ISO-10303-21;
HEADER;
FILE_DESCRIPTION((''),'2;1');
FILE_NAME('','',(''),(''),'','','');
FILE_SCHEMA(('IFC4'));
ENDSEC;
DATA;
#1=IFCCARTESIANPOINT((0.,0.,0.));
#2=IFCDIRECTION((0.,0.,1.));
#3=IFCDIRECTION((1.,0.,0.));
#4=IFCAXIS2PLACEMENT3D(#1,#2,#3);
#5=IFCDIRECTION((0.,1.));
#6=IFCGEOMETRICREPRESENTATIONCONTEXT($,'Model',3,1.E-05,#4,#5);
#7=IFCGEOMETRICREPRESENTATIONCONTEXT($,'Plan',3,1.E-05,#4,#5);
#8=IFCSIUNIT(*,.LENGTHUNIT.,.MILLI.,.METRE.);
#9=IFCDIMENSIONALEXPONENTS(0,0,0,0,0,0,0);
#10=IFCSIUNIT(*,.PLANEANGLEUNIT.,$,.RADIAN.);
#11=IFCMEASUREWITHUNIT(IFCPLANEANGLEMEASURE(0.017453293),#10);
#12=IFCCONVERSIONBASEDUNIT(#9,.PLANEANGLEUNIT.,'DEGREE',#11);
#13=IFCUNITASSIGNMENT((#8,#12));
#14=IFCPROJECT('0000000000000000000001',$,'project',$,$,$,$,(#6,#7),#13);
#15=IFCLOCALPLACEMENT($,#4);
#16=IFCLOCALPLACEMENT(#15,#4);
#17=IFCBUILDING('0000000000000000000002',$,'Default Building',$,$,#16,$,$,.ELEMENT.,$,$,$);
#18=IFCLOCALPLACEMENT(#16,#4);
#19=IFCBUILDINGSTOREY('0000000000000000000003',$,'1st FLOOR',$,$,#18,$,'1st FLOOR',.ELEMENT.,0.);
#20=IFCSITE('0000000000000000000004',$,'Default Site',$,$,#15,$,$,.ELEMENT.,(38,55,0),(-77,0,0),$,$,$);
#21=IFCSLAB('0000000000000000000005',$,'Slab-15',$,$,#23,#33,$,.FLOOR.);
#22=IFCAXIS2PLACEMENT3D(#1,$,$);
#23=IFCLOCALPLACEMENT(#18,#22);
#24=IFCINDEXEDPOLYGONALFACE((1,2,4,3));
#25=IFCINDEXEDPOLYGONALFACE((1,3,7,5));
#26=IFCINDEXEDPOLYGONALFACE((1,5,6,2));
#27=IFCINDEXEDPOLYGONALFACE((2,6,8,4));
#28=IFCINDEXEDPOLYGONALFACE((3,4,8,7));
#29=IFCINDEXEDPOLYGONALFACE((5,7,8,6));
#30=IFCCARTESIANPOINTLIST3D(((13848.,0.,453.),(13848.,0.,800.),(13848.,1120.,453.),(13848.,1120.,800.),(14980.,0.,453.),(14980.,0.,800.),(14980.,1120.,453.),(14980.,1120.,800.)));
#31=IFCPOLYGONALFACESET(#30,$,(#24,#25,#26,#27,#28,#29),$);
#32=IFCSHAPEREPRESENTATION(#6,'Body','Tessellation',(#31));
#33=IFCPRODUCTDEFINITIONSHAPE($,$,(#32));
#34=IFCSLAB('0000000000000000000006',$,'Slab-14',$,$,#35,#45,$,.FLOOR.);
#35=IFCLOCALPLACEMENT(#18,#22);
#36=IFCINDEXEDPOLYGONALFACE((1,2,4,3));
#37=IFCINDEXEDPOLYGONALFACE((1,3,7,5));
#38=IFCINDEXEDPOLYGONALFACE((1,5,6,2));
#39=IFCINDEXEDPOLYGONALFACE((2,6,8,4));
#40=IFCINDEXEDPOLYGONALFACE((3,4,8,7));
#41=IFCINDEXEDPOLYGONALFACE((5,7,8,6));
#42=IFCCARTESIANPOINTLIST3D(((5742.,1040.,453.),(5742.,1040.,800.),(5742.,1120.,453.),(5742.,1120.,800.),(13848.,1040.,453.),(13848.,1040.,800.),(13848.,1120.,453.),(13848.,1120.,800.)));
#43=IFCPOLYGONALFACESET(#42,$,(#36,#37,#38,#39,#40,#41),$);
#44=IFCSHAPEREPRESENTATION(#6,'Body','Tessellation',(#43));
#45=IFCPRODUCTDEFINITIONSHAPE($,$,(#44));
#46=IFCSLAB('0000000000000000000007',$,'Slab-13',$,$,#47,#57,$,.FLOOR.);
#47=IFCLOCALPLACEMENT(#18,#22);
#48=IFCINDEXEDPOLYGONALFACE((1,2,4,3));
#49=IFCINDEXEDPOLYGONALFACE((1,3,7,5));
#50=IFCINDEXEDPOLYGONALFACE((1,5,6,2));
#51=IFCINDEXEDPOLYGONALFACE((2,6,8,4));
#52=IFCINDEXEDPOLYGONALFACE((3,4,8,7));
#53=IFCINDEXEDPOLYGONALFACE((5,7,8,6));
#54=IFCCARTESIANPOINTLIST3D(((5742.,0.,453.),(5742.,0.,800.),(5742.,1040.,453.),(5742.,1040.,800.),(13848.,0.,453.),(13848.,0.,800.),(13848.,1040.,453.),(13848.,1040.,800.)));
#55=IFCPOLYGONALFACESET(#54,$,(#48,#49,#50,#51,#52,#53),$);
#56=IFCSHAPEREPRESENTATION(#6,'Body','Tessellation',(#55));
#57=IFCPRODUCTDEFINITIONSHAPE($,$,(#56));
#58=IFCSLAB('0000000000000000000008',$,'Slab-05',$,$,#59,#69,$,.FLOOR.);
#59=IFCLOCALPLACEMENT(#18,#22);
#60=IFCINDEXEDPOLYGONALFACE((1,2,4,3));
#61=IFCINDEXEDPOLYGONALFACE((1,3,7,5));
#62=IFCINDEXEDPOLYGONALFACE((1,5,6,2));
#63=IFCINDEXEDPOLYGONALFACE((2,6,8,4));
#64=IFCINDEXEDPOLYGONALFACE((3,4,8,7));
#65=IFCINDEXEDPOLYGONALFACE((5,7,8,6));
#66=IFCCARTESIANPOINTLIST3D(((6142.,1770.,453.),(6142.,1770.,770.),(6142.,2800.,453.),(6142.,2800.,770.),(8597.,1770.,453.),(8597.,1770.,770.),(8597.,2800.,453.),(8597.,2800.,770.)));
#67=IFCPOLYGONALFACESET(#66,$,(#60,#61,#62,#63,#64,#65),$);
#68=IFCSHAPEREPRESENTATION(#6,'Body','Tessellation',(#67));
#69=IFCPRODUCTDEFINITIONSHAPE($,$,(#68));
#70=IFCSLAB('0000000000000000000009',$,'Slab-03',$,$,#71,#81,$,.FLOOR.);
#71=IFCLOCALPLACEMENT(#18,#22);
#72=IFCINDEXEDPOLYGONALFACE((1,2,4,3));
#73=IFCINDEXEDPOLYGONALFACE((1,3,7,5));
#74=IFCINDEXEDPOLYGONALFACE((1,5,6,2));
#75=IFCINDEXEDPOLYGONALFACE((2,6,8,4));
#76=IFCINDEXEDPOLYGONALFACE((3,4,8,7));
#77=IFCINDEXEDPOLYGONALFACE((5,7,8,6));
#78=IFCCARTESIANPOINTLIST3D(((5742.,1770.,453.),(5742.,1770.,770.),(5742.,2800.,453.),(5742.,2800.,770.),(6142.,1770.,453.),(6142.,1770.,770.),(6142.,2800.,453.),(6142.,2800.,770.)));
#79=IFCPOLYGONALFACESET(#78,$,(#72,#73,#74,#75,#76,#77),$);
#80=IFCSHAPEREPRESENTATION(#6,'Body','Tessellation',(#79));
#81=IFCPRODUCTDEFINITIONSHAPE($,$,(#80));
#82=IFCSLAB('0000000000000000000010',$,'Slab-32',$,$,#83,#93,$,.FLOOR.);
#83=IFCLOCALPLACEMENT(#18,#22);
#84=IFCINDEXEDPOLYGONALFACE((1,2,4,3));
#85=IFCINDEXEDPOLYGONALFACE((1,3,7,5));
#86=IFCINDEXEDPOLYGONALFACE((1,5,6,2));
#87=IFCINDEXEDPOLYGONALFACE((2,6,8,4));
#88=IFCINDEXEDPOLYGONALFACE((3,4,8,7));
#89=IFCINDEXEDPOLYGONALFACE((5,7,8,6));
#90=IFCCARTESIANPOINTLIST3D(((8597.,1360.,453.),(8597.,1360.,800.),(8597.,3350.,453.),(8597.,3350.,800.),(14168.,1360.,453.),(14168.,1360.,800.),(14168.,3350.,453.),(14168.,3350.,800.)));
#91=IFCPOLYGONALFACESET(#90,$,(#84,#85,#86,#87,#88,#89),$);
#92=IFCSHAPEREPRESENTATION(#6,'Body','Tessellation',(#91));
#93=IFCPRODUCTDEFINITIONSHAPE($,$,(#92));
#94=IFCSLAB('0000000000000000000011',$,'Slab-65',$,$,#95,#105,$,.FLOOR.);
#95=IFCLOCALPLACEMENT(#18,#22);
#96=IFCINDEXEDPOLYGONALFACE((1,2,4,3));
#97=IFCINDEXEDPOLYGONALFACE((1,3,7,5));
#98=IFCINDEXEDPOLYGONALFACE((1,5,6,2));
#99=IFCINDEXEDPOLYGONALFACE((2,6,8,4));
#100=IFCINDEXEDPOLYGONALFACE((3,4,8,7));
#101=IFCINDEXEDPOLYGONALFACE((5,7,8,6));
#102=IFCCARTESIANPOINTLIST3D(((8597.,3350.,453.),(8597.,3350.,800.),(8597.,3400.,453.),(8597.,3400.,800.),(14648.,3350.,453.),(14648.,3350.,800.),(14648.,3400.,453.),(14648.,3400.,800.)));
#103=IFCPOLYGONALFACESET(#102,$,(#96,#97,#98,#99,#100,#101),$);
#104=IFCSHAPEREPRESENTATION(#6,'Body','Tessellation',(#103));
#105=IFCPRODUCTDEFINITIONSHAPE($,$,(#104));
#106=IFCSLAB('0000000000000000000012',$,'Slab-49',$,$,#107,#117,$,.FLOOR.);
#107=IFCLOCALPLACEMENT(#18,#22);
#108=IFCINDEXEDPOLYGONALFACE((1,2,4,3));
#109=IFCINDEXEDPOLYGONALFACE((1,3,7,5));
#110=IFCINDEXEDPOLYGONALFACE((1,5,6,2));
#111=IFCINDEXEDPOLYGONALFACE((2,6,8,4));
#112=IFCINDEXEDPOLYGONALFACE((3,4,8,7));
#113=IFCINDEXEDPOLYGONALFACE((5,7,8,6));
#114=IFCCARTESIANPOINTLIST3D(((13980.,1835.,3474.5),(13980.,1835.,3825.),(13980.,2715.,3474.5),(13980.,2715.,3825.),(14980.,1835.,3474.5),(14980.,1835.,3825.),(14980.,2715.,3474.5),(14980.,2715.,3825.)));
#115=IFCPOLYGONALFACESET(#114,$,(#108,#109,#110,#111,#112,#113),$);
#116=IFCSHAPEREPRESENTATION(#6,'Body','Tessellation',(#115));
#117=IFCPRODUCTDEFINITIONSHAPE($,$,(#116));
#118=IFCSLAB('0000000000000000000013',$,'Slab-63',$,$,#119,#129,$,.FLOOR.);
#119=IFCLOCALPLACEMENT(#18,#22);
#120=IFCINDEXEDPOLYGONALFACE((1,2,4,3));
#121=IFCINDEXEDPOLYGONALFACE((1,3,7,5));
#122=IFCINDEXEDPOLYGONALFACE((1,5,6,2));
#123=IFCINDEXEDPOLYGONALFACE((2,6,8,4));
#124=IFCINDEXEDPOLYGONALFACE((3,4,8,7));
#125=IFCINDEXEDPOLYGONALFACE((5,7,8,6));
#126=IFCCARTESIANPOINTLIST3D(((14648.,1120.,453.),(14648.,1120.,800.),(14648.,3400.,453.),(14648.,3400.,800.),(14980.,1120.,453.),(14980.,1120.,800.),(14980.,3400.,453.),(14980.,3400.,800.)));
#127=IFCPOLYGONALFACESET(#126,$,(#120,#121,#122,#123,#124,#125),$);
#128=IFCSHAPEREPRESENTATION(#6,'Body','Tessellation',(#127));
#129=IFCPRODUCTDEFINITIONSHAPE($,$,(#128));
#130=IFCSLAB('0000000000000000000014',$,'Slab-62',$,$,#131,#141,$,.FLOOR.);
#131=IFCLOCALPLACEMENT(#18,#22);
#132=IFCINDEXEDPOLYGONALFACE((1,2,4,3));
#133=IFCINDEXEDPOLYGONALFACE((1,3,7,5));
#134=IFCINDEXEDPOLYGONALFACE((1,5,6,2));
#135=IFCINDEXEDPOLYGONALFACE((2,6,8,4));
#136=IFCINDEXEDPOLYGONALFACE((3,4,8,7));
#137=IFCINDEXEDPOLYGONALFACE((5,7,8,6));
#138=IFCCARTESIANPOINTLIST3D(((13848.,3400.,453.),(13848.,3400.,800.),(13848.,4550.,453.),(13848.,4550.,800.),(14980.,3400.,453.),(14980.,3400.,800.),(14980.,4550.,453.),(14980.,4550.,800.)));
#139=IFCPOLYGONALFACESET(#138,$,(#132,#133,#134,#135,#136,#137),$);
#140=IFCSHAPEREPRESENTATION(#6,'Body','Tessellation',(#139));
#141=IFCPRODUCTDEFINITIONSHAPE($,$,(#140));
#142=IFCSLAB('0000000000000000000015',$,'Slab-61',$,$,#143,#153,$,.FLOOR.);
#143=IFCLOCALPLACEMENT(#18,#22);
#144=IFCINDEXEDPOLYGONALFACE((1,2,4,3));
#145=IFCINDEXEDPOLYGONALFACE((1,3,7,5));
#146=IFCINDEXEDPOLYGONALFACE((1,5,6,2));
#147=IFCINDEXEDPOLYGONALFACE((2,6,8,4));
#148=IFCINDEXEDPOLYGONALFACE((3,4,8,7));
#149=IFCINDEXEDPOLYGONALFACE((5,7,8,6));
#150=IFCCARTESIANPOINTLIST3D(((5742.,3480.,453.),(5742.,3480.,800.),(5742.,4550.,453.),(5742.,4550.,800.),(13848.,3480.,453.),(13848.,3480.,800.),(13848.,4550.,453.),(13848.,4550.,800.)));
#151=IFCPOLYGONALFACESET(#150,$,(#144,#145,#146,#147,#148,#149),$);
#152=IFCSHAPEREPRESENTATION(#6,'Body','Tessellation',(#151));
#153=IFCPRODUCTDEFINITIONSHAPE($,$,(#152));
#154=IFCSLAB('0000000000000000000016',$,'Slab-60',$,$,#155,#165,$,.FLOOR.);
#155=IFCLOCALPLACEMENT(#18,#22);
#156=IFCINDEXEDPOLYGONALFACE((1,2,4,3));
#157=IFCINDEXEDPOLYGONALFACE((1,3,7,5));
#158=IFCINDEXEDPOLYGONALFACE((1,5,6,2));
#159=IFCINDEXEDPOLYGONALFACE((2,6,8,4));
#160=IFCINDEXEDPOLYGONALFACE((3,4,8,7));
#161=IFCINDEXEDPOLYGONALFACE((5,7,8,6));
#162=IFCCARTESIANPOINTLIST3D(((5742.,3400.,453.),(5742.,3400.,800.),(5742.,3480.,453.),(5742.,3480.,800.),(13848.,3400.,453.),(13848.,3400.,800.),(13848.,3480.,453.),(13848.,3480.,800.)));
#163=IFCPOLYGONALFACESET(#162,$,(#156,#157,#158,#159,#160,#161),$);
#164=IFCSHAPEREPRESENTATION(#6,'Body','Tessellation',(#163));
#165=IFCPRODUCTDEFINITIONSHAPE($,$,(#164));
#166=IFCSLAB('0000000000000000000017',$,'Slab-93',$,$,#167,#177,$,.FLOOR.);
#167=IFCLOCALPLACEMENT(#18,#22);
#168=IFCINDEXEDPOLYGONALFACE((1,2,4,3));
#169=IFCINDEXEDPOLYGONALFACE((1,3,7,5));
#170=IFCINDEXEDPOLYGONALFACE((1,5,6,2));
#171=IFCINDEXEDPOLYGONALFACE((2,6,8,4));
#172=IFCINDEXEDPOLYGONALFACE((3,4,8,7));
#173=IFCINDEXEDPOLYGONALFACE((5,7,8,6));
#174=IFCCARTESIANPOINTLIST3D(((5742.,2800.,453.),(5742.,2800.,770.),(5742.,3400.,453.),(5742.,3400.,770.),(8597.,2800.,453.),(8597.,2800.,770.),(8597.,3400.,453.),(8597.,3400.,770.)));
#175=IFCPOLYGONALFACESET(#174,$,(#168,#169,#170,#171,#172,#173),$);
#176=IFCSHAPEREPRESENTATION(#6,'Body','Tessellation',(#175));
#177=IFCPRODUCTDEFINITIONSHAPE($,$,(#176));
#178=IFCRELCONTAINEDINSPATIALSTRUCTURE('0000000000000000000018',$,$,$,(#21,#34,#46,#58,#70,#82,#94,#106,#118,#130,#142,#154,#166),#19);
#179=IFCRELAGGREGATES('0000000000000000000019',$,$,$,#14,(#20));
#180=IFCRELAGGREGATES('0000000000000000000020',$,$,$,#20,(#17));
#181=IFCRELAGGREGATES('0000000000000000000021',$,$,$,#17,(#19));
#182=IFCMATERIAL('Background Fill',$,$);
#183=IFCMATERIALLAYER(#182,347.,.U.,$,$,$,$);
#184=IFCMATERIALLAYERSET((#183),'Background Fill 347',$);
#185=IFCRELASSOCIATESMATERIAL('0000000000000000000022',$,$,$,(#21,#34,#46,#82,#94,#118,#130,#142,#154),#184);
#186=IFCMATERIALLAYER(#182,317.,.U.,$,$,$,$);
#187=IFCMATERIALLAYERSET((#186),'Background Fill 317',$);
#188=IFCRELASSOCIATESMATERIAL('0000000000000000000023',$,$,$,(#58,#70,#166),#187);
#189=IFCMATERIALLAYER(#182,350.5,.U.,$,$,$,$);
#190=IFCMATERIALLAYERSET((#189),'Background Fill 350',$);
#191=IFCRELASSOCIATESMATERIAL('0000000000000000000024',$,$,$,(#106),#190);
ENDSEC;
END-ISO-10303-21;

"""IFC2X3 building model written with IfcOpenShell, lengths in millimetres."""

from ifc_helpers import new_model, entity, si_unit, converted_unit, direction, frame, origin_with_axes, place, context, project, spatial, polyline, outline, extrude, material, layer, layer_set, layer_usage, element, save


model = new_model("IFC2X3")

# Units and contexts
model_context = context("Model", 3, precision=1e-05, world=origin_with_axes(), true_north=direction((0.0, 1.0)))
plan_context = context("Plan", 3, precision=1e-05, world=origin_with_axes(), true_north=direction((0.0, 1.0)))
ifc_project = project(units=[si_unit("LENGTHUNIT", "METRE", prefix="MILLI"), converted_unit("PLANEANGLEUNIT", "DEGREE", entity("IfcPlaneAngleMeasure", 0.017453293), si_unit("PLANEANGLEUNIT", "RADIAN"), dimensions=[0, 0, 0, 0, 0, 0, 0])], contexts=[model_context, plan_context])

# Site, building, storey
site_placement = place(None, origin_with_axes())
site = spatial("IfcSite", under=ifc_project, at=site_placement, Name="Default Site", CompositionType="ELEMENT", RefLatitude=(38, 55, 0), RefLongitude=(-77, 0, 0))
building_placement = place(site_placement, origin_with_axes())
building = spatial("IfcBuilding", under=site, at=building_placement, Name="Default Building", CompositionType="ELEMENT")
storey_placement = place(building_placement, origin_with_axes())
storey = spatial("IfcBuildingStorey", under=building, at=storey_placement, Name="1st FLOOR", LongName="1st FLOOR", CompositionType="ELEMENT", Elevation=0.0)

# Slabs
ifc_material = material(Name="Background Fill")
ifc_layer_1 = layer(ifc_material, 347.0, ventilated="UNKNOWN")
ifc_layer_set_1 = layer_set([ifc_layer_1], Name="Background Fill 347")
ifc_layer_usage_1 = layer_usage(ifc_layer_set_1, "AXIS3", "NEGATIVE", 347.0)
slab_1_placement = place(storey_placement, frame((13848.0, 0.0, 453.0), z_axis=(0.0, 0.0, 1.0), x_axis=(1.0, 0.0, 0.0)))
element("IfcSlab", 1, at=slab_1_placement, inside=storey, material=ifc_layer_usage_1, Name="Slab-15", PredefinedType="FLOOR", context=model_context, shape_type="SweptSolid", body=[
    extrude(outline(polyline([(0.0, 0.0), (1132.0, 0.0), (1132.0, 1120.0), (0.0, 1120.0), (0.0, 0.0)])), origin_with_axes(), (0.0, 0.0, 1.0), 347.0),
])
ifc_layer_usage_2 = layer_usage(ifc_layer_set_1, "AXIS3", "NEGATIVE", 347.0)
slab_2_placement = place(storey_placement, frame((5742.0, 1040.0, 453.0), z_axis=(0.0, 0.0, 1.0), x_axis=(1.0, 0.0, 0.0)))
element("IfcSlab", 2, at=slab_2_placement, inside=storey, material=ifc_layer_usage_2, Name="Slab-14", PredefinedType="FLOOR", context=model_context, shape_type="SweptSolid", body=[
    extrude(outline(polyline([(0.0, 0.0), (8106.0, 0.0), (8106.0, 80.0), (0.0, 80.0), (0.0, 0.0)])), origin_with_axes(), (0.0, 0.0, 1.0), 347.0),
])
ifc_layer_usage_3 = layer_usage(ifc_layer_set_1, "AXIS3", "NEGATIVE", 347.0)
slab_3_placement = place(storey_placement, frame((5742.0, 0.0, 453.0), z_axis=(0.0, 0.0, 1.0), x_axis=(1.0, 0.0, 0.0)))
element("IfcSlab", 3, at=slab_3_placement, inside=storey, material=ifc_layer_usage_3, Name="Slab-13", PredefinedType="FLOOR", context=model_context, shape_type="SweptSolid", body=[
    extrude(outline(polyline([(0.0, 0.0), (8106.0, 0.0), (8106.0, 1040.0), (0.0, 1040.0), (0.0, 0.0)])), origin_with_axes(), (0.0, 0.0, 1.0), 347.0),
])
ifc_layer_2 = layer(ifc_material, 317.0, ventilated="UNKNOWN")
ifc_layer_set_2 = layer_set([ifc_layer_2], Name="Background Fill 317")
ifc_layer_usage_4 = layer_usage(ifc_layer_set_2, "AXIS3", "NEGATIVE", 317.0)
slab_4_placement = place(storey_placement, frame((6142.0, 1770.0, 453.0), z_axis=(0.0, 0.0, 1.0), x_axis=(1.0, 0.0, 0.0)))
element("IfcSlab", 4, at=slab_4_placement, inside=storey, material=ifc_layer_usage_4, Name="Slab-05", PredefinedType="FLOOR", context=model_context, shape_type="SweptSolid", body=[
    extrude(outline(polyline([(0.0, 0.0), (2455.0, 0.0), (2455.0, 1030.0), (0.0, 1030.0), (0.0, 0.0)])), origin_with_axes(), (0.0, 0.0, 1.0), 317.0),
])
ifc_layer_usage_5 = layer_usage(ifc_layer_set_2, "AXIS3", "NEGATIVE", 317.0)
slab_5_placement = place(storey_placement, frame((5742.0, 1770.0, 453.0), z_axis=(0.0, 0.0, 1.0), x_axis=(1.0, 0.0, 0.0)))
element("IfcSlab", 5, at=slab_5_placement, inside=storey, material=ifc_layer_usage_5, Name="Slab-03", PredefinedType="FLOOR", context=model_context, shape_type="SweptSolid", body=[
    extrude(outline(polyline([(0.0, 0.0), (400.0, 0.0), (400.0, 1030.0), (0.0, 1030.0), (0.0, 0.0)])), origin_with_axes(), (0.0, 0.0, 1.0), 317.0),
])
ifc_layer_usage_6 = layer_usage(ifc_layer_set_1, "AXIS3", "NEGATIVE", 347.0)
slab_6_placement = place(storey_placement, frame((8597.0, 1360.0, 453.0), z_axis=(0.0, 0.0, 1.0), x_axis=(1.0, 0.0, 0.0)))
element("IfcSlab", 6, at=slab_6_placement, inside=storey, material=ifc_layer_usage_6, Name="Slab-32", PredefinedType="FLOOR", context=model_context, shape_type="SweptSolid", body=[
    extrude(outline(polyline([(0.0, 0.0), (5571.0, 0.0), (5571.0, 1990.0), (0.0, 1990.0), (0.0, 0.0)])), origin_with_axes(), (0.0, 0.0, 1.0), 347.0),
])
ifc_layer_usage_7 = layer_usage(ifc_layer_set_1, "AXIS3", "NEGATIVE", 347.0)
slab_7_placement = place(storey_placement, frame((8597.0, 3350.0, 453.0), z_axis=(0.0, 0.0, 1.0), x_axis=(1.0, 0.0, 0.0)))
element("IfcSlab", 7, at=slab_7_placement, inside=storey, material=ifc_layer_usage_7, Name="Slab-65", PredefinedType="FLOOR", context=model_context, shape_type="SweptSolid", body=[
    extrude(outline(polyline([(0.0, 0.0), (6051.0, 0.0), (6051.0, 50.0), (0.0, 50.0), (0.0, 0.0)])), origin_with_axes(), (0.0, 0.0, 1.0), 347.0),
])
ifc_layer_3 = layer(ifc_material, 350.5, ventilated="UNKNOWN")
ifc_layer_set_3 = layer_set([ifc_layer_3], Name="Background Fill 350")
ifc_layer_usage_8 = layer_usage(ifc_layer_set_3, "AXIS3", "NEGATIVE", 350.5)
slab_8_placement = place(storey_placement, frame((13980.0, 1835.0, 3474.5), z_axis=(0.0, 0.0, 1.0), x_axis=(1.0, 0.0, 0.0)))
element("IfcSlab", 8, at=slab_8_placement, inside=storey, material=ifc_layer_usage_8, Name="Slab-49", PredefinedType="FLOOR", context=model_context, shape_type="SweptSolid", body=[
    extrude(outline(polyline([(0.0, 0.0), (1000.0, 0.0), (1000.0, 880.0), (0.0, 880.0), (0.0, 0.0)])), origin_with_axes(), (0.0, 0.0, 1.0), 350.5),
])
ifc_layer_usage_9 = layer_usage(ifc_layer_set_1, "AXIS3", "NEGATIVE", 347.0)
slab_9_placement = place(storey_placement, frame((14648.0, 1120.0, 453.0), z_axis=(0.0, 0.0, 1.0), x_axis=(1.0, 0.0, 0.0)))
element("IfcSlab", 9, at=slab_9_placement, inside=storey, material=ifc_layer_usage_9, Name="Slab-63", PredefinedType="FLOOR", context=model_context, shape_type="SweptSolid", body=[
    extrude(outline(polyline([(0.0, 0.0), (332.0, 0.0), (332.0, 2280.0), (0.0, 2280.0), (0.0, 0.0)])), origin_with_axes(), (0.0, 0.0, 1.0), 347.0),
])
ifc_layer_usage_10 = layer_usage(ifc_layer_set_1, "AXIS3", "NEGATIVE", 347.0)
slab_10_placement = place(storey_placement, frame((13848.0, 3400.0, 453.0), z_axis=(0.0, 0.0, 1.0), x_axis=(1.0, 0.0, 0.0)))
element("IfcSlab", 10, at=slab_10_placement, inside=storey, material=ifc_layer_usage_10, Name="Slab-62", PredefinedType="FLOOR", context=model_context, shape_type="SweptSolid", body=[
    extrude(outline(polyline([(0.0, 0.0), (1132.0, 0.0), (1132.0, 1150.0), (0.0, 1150.0), (0.0, 0.0)])), origin_with_axes(), (0.0, 0.0, 1.0), 347.0),
])
ifc_layer_usage_11 = layer_usage(ifc_layer_set_1, "AXIS3", "NEGATIVE", 347.0)
slab_11_placement = place(storey_placement, frame((5742.0, 3480.0, 453.0), z_axis=(0.0, 0.0, 1.0), x_axis=(1.0, 0.0, 0.0)))
element("IfcSlab", 11, at=slab_11_placement, inside=storey, material=ifc_layer_usage_11, Name="Slab-61", PredefinedType="FLOOR", context=model_context, shape_type="SweptSolid", body=[
    extrude(outline(polyline([(0.0, 0.0), (8106.0, 0.0), (8106.0, 1070.0), (0.0, 1070.0), (0.0, 0.0)])), origin_with_axes(), (0.0, 0.0, 1.0), 347.0),
])
ifc_layer_usage_12 = layer_usage(ifc_layer_set_1, "AXIS3", "NEGATIVE", 347.0)
slab_12_placement = place(storey_placement, frame((5742.0, 3400.0, 453.0), z_axis=(0.0, 0.0, 1.0), x_axis=(1.0, 0.0, 0.0)))
element("IfcSlab", 12, at=slab_12_placement, inside=storey, material=ifc_layer_usage_12, Name="Slab-60", PredefinedType="FLOOR", context=model_context, shape_type="SweptSolid", body=[
    extrude(outline(polyline([(0.0, 0.0), (8106.0, 0.0), (8106.0, 80.0), (0.0, 80.0), (0.0, 0.0)])), origin_with_axes(), (0.0, 0.0, 1.0), 347.0),
])
ifc_layer_usage_13 = layer_usage(ifc_layer_set_2, "AXIS3", "NEGATIVE", 317.0)
slab_13_placement = place(storey_placement, frame((5742.0, 2800.0, 453.0), z_axis=(0.0, 0.0, 1.0), x_axis=(1.0, 0.0, 0.0)))
element("IfcSlab", 13, at=slab_13_placement, inside=storey, material=ifc_layer_usage_13, Name="Slab-93", PredefinedType="FLOOR", context=model_context, shape_type="SweptSolid", body=[
    extrude(outline(polyline([(0.0, 0.0), (2855.0, 0.0), (2855.0, 600.0), (0.0, 600.0), (0.0, 0.0)])), origin_with_axes(), (0.0, 0.0, 1.0), 317.0),
])

save(model, "model.ifc")
